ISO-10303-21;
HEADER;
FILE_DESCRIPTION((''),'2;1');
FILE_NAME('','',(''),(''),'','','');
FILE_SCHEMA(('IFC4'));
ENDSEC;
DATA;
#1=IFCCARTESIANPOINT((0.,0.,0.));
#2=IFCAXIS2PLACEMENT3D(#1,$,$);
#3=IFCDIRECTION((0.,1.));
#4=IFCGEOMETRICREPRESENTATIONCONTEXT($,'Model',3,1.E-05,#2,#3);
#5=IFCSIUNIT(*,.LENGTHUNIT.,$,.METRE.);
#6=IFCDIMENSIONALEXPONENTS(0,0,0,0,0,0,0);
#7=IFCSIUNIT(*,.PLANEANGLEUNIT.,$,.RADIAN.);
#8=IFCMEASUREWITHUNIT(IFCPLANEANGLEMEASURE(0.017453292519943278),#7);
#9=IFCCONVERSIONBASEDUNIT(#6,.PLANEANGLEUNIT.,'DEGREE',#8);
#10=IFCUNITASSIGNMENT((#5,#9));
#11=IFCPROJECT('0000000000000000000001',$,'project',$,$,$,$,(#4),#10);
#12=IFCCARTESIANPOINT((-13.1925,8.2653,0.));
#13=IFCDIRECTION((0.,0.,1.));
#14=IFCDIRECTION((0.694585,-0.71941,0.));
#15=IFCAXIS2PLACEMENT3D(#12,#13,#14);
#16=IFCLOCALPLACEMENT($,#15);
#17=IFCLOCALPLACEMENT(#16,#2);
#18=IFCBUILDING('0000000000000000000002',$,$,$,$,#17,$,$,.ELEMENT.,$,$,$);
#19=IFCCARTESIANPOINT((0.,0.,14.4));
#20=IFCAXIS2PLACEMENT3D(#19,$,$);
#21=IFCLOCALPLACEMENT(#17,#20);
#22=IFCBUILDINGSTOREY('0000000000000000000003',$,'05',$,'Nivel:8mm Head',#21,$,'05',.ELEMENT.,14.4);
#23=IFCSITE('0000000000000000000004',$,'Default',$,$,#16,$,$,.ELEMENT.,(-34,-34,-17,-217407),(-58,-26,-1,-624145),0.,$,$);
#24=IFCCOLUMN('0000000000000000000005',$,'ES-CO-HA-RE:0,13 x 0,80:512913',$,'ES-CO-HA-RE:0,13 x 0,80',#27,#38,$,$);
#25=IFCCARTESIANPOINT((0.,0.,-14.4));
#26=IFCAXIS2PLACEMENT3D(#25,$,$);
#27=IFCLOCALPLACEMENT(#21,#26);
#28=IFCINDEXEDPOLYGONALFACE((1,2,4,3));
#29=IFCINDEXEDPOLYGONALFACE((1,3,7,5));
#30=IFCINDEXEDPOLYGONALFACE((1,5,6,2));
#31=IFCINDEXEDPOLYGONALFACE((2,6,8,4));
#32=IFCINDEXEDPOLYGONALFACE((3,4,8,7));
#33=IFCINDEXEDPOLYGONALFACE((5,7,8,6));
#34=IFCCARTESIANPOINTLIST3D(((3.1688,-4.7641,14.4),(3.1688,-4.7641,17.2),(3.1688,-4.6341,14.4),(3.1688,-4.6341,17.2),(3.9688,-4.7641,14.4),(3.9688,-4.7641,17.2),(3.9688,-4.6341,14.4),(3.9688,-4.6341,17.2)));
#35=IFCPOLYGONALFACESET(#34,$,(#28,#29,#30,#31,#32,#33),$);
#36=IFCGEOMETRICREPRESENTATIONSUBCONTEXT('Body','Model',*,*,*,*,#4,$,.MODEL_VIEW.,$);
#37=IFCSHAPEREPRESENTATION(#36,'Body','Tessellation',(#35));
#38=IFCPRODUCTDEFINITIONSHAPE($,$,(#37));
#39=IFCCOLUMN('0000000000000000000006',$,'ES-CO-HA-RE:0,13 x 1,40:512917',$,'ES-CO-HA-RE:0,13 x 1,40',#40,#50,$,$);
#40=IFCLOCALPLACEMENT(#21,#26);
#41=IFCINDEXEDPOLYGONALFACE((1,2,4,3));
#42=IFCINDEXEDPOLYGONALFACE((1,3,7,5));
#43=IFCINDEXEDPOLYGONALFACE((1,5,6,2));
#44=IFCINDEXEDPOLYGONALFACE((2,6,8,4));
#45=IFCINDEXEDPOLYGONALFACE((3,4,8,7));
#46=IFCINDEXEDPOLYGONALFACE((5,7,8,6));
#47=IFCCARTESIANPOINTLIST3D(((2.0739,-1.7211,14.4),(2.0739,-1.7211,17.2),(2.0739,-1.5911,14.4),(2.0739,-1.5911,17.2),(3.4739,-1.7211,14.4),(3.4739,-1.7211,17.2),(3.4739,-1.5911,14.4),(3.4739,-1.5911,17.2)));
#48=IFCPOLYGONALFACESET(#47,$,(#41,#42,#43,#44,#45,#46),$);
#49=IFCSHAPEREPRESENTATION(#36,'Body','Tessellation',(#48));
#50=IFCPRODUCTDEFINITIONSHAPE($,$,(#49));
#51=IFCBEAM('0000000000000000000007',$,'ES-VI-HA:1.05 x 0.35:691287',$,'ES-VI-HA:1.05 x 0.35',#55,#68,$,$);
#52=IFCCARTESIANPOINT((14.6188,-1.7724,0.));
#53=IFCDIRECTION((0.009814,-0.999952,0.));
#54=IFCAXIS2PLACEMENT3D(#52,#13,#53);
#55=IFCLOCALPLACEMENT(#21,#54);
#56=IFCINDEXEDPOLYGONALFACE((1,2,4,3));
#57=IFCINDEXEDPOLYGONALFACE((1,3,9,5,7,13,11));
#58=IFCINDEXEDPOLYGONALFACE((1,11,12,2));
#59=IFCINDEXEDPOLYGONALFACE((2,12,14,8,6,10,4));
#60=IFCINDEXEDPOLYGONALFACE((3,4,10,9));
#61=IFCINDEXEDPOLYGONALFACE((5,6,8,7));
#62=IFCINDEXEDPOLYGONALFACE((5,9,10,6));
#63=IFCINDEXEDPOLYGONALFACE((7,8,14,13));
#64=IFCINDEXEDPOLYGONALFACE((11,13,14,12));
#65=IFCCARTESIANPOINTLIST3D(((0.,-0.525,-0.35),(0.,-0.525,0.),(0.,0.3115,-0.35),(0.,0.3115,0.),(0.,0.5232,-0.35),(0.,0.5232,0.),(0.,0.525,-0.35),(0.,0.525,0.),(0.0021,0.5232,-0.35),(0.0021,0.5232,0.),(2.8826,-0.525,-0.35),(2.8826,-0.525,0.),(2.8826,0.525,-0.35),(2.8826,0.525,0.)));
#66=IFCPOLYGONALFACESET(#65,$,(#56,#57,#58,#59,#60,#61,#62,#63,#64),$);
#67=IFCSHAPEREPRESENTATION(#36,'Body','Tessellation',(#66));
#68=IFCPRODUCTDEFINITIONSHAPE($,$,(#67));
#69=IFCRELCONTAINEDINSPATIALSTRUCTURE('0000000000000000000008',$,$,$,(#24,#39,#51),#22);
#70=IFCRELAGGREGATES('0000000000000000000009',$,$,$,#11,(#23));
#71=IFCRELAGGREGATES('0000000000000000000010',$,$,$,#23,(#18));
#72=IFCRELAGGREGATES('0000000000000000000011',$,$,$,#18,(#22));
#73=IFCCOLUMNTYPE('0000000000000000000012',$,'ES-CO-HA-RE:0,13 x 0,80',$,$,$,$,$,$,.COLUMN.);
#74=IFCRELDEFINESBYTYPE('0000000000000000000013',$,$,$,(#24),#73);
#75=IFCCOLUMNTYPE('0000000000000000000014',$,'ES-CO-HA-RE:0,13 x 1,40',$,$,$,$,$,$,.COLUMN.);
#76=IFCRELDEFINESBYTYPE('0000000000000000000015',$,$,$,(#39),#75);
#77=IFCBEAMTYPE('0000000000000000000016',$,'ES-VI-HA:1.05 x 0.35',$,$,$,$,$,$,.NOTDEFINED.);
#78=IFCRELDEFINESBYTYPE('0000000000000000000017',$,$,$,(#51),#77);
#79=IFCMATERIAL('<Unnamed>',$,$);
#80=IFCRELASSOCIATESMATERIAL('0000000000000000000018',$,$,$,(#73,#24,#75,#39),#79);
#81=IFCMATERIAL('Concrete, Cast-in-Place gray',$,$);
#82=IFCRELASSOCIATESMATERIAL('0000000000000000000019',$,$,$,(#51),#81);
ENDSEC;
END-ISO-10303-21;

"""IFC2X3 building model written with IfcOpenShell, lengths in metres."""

from ifc_helpers import new_model, entity, si_unit, converted_unit, direction, frame, frame_2d, origin, place, context, subcontext, project, spatial, polyline, rectangle, extrude, clip, bounded_halfspace, source, transform, mapped, material, type_object, type_shapes, element, save


model = new_model("IFC2X3")

# Units and contexts
model_context = context("Model", 3, precision=1e-05, world=origin(), true_north=direction((0.0, 1.0)))
body_context = subcontext(model_context, "Body", "Model", "MODEL_VIEW")
ifc_project = project(units=[si_unit("LENGTHUNIT", "METRE"), converted_unit("PLANEANGLEUNIT", "DEGREE", entity("IfcPlaneAngleMeasure", 0.017453292519943278), si_unit("PLANEANGLEUNIT", "RADIAN"), dimensions=[0, 0, 0, 0, 0, 0, 0])], contexts=[model_context])

# Site, building, storey
site_placement = place(None, frame((-13.1925, 8.2653, 0.0), z_axis=(0.0, 0.0, 1.0), x_axis=(0.694585, -0.71941, 0.0)))
site = spatial("IfcSite", under=ifc_project, at=site_placement, Name="Default", CompositionType="ELEMENT", RefLatitude=(-34, -34, -17, -217407), RefLongitude=(-58, -26, -1, -624145), RefElevation=0.0)
building_placement = place(site_placement, origin())
building = spatial("IfcBuilding", under=site, at=building_placement, CompositionType="ELEMENT")
storey_placement = place(building_placement, frame((0.0, 0.0, 14.4)))
storey = spatial("IfcBuildingStorey", under=building, at=storey_placement, Name="05", ObjectType="Nivel:8mm Head", LongName="05", CompositionType="ELEMENT", Elevation=14.4)

# Columns
ifc_material_1 = material(Name="<Unnamed>")
column_type_1 = type_object("IfcColumnType", Name="ES-CO-HA-RE:0,13 x 0,80", PredefinedType="COLUMN", material=ifc_material_1)
shared_shape_1 = source(origin(), body_context, "Body", "SweptSolid", [
    extrude(rectangle(XDim=0.8, YDim=0.13, at=frame_2d((0.0, 0.0), x_axis=(1.0, 0.0))), frame((3.5688, -4.6991, 14.4), z_axis=(0.0, 0.0, 1.0), x_axis=(-1.0, 0.0, 0.0)), (0.0, 0.0, 1.0), 2.8),
])
type_shapes(column_type_1, [shared_shape_1])
column_1_placement = place(storey_placement, frame((0.0, 0.0, -14.4)))
element("IfcColumn", 1, at=column_1_placement, inside=storey, type_object=column_type_1, material=ifc_material_1, Name="ES-CO-HA-RE:0,13 x 0,80:512913", ObjectType="ES-CO-HA-RE:0,13 x 0,80", context=body_context, shape_type="MappedRepresentation", body=[
    mapped(shared_shape_1, transform((0.0, 0.0, 0.0), scale=1.0)),
])
column_type_2 = type_object("IfcColumnType", Name="ES-CO-HA-RE:0,13 x 1,40", PredefinedType="COLUMN", material=ifc_material_1)
shared_shape_2 = source(origin(), body_context, "Body", "SweptSolid", [
    extrude(rectangle(XDim=1.4, YDim=0.13, at=frame_2d((0.0, 0.0), x_axis=(1.0, 0.0))), frame((2.7739, -1.6561, 14.4), z_axis=(0.0, 0.0, 1.0), x_axis=(-1.0, 0.0, 0.0)), (0.0, 0.0, 1.0), 2.8),
])
type_shapes(column_type_2, [shared_shape_2])
column_2_placement = place(storey_placement, frame((0.0, 0.0, -14.4)))
element("IfcColumn", 2, at=column_2_placement, inside=storey, type_object=column_type_2, material=ifc_material_1, Name="ES-CO-HA-RE:0,13 x 1,40:512917", ObjectType="ES-CO-HA-RE:0,13 x 1,40", context=body_context, shape_type="MappedRepresentation", body=[
    mapped(shared_shape_2, transform((0.0, 0.0, 0.0), scale=1.0)),
])

# Beam
ifc_material_2 = material(Name="Concrete, Cast-in-Place gray")
beam_type_1 = type_object("IfcBeamType", Name="ES-VI-HA:1.05 x 0.35", PredefinedType="NOTDEFINED")
beam_1_placement = place(storey_placement, frame((14.6188, -1.7724, 0.0), z_axis=(0.0, 0.0, 1.0), x_axis=(0.009814, -0.999952, 0.0)))
element("IfcBeam", 3, at=beam_1_placement, inside=storey, type_object=beam_type_1, material=ifc_material_2, Name="ES-VI-HA:1.05 x 0.35:691287", ObjectType="ES-VI-HA:1.05 x 0.35", context=body_context, shape_type="SweptSolid", body=[
    clip(clip(extrude(rectangle(XDim=0.35, YDim=1.05, at=frame_2d((0.0, 0.0), x_axis=(1.0, 0.0))), frame((0.0, 0.0, -0.175), z_axis=(1.0, 0.0, 0.0), x_axis=(0.0, 0.0, -1.0)), (0.0, 0.0, 1.0), 2.8826), bounded_halfspace(frame((0.0021, 0.5232, 0.0), z_axis=(-0.009814, -0.999952, 0.0), x_axis=(0.0, 0.0, -1.0)), False, frame((0.0, 0.0, -0.175), z_axis=(1.0, 0.0, 0.0), x_axis=(0.0, 0.0, -1.0)), polyline([(0.175, 0.5232), (-0.175, 0.5232), (-0.175, 0.5232), (0.175, 0.5232), (0.175, 0.5232)]))), bounded_halfspace(frame((-0.0082, -0.5268, 0.0), z_axis=(-0.999952, 0.009814, 0.0), x_axis=(0.0, 0.0, -1.0)), False, frame((0.0, 0.0, -0.175), z_axis=(1.0, 0.0, 0.0), x_axis=(0.0, 0.0, -1.0)), polyline([(-0.175, 0.5232), (0.175, 0.5232), (0.175, 0.3115), (-0.175, 0.3115), (-0.175, 0.5232)]))),
])

save(model, "model.ifc")
